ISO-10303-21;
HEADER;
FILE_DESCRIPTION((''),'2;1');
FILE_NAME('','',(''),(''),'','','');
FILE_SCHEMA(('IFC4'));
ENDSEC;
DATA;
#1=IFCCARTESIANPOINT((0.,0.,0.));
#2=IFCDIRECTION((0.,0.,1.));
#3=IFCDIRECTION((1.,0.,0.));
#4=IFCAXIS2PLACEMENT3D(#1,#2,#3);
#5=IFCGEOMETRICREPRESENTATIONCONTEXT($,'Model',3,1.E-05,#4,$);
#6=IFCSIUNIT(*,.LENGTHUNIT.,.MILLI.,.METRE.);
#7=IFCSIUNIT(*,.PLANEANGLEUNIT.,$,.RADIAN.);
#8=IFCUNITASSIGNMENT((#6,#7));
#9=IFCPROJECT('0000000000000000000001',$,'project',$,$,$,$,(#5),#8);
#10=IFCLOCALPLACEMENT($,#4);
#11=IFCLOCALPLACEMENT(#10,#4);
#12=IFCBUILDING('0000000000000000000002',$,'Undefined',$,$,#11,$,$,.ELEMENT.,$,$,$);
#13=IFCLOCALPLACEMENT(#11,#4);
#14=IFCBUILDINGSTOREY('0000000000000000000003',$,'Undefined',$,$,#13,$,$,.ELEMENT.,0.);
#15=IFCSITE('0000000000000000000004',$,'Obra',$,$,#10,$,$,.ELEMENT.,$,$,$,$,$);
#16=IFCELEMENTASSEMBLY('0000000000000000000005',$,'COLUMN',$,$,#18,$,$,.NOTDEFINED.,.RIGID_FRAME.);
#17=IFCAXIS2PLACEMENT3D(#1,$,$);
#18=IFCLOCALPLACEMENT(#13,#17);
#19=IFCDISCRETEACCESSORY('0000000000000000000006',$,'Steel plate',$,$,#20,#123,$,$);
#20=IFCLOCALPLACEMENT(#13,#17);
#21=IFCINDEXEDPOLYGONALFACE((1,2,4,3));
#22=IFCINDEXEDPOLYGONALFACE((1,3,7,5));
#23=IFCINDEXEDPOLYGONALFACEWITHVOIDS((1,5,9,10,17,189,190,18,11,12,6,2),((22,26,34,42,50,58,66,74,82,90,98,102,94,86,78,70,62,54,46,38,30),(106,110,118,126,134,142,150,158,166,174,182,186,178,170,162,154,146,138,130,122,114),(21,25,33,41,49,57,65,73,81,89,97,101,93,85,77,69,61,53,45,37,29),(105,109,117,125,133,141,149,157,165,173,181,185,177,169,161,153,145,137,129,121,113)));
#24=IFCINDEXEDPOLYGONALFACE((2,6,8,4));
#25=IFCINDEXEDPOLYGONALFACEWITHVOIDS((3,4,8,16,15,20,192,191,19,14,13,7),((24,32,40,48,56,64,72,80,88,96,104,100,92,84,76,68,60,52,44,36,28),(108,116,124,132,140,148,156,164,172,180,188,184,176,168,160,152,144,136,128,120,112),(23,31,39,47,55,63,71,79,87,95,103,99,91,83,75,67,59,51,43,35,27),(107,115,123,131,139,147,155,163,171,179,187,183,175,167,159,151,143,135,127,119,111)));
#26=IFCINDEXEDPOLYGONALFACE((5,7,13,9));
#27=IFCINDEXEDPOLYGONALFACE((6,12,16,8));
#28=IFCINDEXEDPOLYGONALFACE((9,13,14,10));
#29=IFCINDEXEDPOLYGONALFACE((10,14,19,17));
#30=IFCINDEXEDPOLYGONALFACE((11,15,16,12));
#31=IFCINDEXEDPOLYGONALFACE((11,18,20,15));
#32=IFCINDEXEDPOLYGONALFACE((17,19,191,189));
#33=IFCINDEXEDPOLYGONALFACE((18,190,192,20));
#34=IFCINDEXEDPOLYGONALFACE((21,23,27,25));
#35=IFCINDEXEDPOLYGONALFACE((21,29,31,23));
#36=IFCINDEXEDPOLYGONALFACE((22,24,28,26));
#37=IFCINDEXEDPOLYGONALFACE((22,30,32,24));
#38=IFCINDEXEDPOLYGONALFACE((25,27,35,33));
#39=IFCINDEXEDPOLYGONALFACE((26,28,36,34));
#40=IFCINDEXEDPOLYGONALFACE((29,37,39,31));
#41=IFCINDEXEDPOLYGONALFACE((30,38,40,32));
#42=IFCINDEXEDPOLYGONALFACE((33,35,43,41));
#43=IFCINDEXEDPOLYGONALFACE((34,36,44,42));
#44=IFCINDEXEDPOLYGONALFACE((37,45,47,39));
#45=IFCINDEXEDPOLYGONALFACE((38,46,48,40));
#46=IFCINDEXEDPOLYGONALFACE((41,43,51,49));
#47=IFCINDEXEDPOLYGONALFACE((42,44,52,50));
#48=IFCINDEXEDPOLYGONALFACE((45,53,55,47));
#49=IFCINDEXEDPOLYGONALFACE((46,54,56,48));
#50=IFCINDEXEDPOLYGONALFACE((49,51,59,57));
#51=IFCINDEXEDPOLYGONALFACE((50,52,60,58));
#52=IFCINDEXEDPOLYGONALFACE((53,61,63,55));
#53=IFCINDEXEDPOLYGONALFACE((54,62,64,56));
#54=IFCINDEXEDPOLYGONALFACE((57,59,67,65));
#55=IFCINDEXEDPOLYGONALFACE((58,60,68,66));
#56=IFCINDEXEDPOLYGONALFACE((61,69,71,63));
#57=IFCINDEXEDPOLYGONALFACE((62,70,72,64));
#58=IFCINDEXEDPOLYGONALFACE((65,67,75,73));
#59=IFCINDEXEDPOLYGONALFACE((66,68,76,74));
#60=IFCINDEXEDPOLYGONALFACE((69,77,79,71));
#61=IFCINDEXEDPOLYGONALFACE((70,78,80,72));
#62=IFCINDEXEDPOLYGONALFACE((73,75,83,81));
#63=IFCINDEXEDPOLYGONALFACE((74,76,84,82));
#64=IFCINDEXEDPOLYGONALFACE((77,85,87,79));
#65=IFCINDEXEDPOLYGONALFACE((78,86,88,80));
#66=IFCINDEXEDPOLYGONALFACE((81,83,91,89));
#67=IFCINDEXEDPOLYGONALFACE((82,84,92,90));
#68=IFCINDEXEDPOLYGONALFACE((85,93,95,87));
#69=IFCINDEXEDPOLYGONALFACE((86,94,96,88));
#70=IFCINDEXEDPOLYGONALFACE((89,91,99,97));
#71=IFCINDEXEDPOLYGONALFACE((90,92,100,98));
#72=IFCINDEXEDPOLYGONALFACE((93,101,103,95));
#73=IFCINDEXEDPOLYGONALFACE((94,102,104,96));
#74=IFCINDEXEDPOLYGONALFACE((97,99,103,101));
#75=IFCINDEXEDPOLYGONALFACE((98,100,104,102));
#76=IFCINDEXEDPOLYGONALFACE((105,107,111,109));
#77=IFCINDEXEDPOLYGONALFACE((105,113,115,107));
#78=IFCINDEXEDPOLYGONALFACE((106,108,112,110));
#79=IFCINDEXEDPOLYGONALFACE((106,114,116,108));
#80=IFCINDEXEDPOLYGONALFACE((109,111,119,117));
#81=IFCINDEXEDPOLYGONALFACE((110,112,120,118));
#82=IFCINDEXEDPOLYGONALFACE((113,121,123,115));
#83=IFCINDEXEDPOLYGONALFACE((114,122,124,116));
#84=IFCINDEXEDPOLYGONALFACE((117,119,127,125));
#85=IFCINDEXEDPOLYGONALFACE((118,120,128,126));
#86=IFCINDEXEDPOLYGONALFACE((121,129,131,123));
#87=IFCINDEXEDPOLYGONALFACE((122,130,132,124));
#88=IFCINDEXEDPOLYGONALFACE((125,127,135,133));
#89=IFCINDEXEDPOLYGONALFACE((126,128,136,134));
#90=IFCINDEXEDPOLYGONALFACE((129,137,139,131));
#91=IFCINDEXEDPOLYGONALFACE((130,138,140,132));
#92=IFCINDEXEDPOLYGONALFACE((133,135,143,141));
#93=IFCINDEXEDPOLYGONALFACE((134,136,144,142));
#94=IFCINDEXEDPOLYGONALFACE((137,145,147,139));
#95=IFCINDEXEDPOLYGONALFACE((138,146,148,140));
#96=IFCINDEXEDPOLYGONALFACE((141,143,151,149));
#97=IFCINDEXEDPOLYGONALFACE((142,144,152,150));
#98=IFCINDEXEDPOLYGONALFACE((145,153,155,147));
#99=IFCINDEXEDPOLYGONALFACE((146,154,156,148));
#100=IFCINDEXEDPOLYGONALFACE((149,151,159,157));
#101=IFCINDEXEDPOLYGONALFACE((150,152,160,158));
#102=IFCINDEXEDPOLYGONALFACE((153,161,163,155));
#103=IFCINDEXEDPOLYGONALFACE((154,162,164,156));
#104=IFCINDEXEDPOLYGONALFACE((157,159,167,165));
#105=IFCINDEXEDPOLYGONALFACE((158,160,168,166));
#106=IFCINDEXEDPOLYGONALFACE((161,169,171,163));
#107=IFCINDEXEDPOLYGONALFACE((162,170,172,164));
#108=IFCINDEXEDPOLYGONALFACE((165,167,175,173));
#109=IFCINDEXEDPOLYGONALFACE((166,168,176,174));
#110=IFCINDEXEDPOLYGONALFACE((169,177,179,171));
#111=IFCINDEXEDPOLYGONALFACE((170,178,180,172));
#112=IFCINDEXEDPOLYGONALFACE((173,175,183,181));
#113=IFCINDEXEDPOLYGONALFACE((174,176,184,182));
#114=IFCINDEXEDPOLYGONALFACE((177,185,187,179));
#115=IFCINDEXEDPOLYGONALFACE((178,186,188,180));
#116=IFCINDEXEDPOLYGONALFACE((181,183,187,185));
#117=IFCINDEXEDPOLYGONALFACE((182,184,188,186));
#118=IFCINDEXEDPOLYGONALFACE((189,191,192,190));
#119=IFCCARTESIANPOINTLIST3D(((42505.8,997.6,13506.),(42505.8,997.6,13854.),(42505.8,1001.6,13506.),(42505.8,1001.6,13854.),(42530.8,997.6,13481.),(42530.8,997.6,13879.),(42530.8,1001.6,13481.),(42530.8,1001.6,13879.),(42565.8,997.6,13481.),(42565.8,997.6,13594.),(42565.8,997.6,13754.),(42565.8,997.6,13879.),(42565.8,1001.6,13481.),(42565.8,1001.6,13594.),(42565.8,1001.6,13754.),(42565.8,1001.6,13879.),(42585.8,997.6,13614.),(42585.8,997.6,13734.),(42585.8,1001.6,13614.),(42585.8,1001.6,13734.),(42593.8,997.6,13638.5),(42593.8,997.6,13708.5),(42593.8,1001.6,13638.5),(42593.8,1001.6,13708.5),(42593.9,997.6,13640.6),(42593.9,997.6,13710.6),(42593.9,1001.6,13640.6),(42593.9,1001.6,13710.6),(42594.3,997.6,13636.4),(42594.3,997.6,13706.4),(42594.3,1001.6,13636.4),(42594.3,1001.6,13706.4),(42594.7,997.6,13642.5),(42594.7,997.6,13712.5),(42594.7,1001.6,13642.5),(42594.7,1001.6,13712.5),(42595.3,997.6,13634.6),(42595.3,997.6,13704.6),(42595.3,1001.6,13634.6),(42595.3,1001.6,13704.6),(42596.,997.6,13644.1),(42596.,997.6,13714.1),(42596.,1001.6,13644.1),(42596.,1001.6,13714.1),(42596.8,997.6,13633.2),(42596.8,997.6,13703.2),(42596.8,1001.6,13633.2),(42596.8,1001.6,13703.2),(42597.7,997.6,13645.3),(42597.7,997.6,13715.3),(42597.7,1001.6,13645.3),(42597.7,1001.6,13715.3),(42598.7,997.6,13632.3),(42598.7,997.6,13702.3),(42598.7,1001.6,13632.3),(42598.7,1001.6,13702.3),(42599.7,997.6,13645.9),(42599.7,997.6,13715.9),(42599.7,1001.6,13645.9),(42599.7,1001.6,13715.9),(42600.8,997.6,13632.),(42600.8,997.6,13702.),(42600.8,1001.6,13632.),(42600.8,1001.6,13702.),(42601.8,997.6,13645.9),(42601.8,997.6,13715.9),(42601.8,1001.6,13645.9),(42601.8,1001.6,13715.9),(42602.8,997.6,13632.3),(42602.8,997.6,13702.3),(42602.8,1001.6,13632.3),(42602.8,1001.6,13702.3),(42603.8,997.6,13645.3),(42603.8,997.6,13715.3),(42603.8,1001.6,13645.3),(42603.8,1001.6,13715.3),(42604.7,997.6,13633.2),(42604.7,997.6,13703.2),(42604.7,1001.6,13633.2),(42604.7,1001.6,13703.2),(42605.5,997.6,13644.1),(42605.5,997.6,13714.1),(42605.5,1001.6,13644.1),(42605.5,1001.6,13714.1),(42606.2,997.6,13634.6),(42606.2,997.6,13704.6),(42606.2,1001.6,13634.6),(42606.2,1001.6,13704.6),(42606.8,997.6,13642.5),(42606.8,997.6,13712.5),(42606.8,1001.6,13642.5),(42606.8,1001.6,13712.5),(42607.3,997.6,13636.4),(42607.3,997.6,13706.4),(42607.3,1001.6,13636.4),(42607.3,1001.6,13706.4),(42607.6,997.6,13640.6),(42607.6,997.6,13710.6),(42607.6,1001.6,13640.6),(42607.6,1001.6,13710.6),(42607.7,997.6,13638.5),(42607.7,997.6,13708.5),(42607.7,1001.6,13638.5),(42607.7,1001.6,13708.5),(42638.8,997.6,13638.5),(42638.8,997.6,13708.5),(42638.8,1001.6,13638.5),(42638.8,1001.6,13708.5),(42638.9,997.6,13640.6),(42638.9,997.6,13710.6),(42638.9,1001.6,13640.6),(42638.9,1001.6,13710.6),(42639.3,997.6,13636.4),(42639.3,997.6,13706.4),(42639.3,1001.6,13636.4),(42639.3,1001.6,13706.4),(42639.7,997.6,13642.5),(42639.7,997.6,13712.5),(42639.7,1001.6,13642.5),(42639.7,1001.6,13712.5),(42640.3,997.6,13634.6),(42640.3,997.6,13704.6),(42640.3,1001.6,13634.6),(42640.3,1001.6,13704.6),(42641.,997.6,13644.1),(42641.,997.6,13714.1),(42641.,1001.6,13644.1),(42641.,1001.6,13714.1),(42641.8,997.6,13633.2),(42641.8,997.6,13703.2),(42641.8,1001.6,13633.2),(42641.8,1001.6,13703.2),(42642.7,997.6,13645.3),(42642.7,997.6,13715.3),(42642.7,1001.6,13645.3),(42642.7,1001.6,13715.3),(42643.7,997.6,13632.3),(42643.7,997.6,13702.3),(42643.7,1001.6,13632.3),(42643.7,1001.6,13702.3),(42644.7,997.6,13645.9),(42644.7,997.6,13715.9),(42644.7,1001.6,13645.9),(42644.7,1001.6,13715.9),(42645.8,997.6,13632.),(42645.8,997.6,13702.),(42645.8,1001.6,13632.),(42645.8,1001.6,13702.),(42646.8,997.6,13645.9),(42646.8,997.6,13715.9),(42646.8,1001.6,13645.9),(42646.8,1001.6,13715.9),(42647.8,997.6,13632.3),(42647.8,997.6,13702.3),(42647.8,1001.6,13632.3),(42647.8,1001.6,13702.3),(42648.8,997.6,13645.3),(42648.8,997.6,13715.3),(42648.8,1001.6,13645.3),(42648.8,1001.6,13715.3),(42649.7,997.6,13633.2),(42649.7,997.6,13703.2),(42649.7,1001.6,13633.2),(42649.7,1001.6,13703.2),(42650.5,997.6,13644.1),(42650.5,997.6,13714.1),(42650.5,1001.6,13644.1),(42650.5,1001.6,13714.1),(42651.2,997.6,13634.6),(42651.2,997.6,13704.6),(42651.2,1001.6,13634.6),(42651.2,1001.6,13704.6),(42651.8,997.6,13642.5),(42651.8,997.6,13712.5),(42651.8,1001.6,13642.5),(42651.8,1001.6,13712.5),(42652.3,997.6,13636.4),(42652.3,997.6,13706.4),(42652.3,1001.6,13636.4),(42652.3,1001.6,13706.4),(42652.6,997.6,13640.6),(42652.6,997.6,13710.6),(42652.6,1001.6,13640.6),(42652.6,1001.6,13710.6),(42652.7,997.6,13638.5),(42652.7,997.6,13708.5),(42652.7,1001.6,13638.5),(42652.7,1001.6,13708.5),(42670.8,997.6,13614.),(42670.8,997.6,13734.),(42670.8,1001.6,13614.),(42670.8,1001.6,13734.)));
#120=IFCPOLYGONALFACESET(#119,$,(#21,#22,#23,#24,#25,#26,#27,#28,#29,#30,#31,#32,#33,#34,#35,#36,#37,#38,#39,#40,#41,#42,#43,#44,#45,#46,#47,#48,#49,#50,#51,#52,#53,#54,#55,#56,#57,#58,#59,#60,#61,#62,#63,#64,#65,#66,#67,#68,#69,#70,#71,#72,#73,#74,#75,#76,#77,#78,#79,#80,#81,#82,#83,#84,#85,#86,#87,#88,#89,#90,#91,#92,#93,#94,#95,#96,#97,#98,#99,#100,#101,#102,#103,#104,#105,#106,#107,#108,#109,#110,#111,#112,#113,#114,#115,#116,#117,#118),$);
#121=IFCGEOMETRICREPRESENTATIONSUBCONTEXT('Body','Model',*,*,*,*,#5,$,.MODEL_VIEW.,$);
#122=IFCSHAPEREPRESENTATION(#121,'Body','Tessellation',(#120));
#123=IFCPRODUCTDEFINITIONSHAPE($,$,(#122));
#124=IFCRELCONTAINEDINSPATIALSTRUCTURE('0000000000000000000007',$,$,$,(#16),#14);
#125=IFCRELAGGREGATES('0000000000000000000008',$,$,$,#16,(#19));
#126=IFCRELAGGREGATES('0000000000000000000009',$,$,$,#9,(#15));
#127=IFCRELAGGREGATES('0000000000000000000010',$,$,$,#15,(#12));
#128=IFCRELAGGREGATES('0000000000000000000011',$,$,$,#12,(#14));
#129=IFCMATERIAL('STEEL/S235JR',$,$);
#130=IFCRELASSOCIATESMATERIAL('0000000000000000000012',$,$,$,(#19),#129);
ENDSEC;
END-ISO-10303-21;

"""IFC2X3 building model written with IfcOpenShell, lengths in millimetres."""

from ifc_helpers import new_model, si_unit, frame, origin_with_axes, origin_2d_with_axis, place, context, subcontext, project, spatial, polyline, circle, outline, extrude, source, transform, mapped, material, element, aggregate, save


model = new_model("IFC2X3")

# Units and contexts
model_context = context("Model", 3, precision=1e-05, world=origin_with_axes())
body_context = subcontext(model_context, "Body", "Model", "MODEL_VIEW")
ifc_project = project(units=[si_unit("LENGTHUNIT", "METRE", prefix="MILLI"), si_unit("PLANEANGLEUNIT", "RADIAN")], contexts=[model_context])

# Site, building, storey
site_placement = place(None, origin_with_axes())
site = spatial("IfcSite", under=ifc_project, at=site_placement, Name="Obra", CompositionType="ELEMENT")
building_placement = place(site_placement, origin_with_axes())
building = spatial("IfcBuilding", under=site, at=building_placement, Name="Undefined", CompositionType="ELEMENT")
storey_placement = place(building_placement, origin_with_axes())
storey = spatial("IfcBuildingStorey", under=building, at=storey_placement, Name="Undefined", CompositionType="ELEMENT", Elevation=0.0)

# Element assembly
assembly_1_placement = place(storey_placement, origin_with_axes())
assembly_1 = element("IfcElementAssembly", 1, at=assembly_1_placement, inside=storey, Name="COLUMN", AssemblyPlace="NOTDEFINED", PredefinedType="RIGID_FRAME")
ifc_material_1 = material(Name="STEEL/S235JR")

# Discrete accessory, opening
discrete_accessory_1_placement = place(assembly_1_placement, frame((42505.8, 999.6, 13506.0), z_axis=(-0.000023, -1.0, 0.0), x_axis=(0.707107, -0.000016, -0.707107)))
discrete_accessory_1 = element("IfcDiscreteAccessory", 2, at=discrete_accessory_1_placement, material=ifc_material_1, Name="Steel plate", context=body_context, shape_type="SweptSolid", body=[
    extrude(outline(polyline([(0.0, 0.0), (35.4, 0.0), (60.1, 24.7), (-19.8, 104.7), (-19.8, 132.9), (40.3, 193.0), (-44.5, 277.9), (-104.7, 217.8), (-132.9, 217.8), (-221.3, 306.2), (-246.1, 281.4), (-246.1, 246.1), (0.0, 0.0)])), frame((0.0, 0.0, -2.0), z_axis=(0.0, 0.0, 1.0), x_axis=(1.0, 0.0, 0.0)), (0.0, 0.0, 1.0), 4.0),
])
shared_shape_1 = source(origin_with_axes(), body_context, "Body", "SweptSolid", [
    extrude(circle(Radius=7.0, at=origin_2d_with_axis()), frame((0.0, -36.6, 0.0), z_axis=(0.0, 1.0, 0.0), x_axis=(1.0, 0.0, 0.0)), (0.0, 0.0, 1.0), 4.2),
])
opening_1_placement = place(assembly_1_placement, frame((42575.8, 1034.1, 13734.0), z_axis=(1.0, -0.000022, 0.0), x_axis=(0.0, 0.0, -1.0)))
element("IfcOpeningElement", 3, at=opening_1_placement, cuts=discrete_accessory_1, ObjectType="Opening", context=body_context, shape_type="MappedRepresentation", body=[
    mapped(shared_shape_1, transform((25.0, 0.0, 25.0))),
    mapped(shared_shape_1, transform((25.0, 0.0, 70.0))),
    mapped(shared_shape_1, transform((95.0, 0.0, 25.0))),
    mapped(shared_shape_1, transform((95.0, 0.0, 70.0))),
])
aggregate(assembly_1, [discrete_accessory_1])

save(model, "model.ifc")
